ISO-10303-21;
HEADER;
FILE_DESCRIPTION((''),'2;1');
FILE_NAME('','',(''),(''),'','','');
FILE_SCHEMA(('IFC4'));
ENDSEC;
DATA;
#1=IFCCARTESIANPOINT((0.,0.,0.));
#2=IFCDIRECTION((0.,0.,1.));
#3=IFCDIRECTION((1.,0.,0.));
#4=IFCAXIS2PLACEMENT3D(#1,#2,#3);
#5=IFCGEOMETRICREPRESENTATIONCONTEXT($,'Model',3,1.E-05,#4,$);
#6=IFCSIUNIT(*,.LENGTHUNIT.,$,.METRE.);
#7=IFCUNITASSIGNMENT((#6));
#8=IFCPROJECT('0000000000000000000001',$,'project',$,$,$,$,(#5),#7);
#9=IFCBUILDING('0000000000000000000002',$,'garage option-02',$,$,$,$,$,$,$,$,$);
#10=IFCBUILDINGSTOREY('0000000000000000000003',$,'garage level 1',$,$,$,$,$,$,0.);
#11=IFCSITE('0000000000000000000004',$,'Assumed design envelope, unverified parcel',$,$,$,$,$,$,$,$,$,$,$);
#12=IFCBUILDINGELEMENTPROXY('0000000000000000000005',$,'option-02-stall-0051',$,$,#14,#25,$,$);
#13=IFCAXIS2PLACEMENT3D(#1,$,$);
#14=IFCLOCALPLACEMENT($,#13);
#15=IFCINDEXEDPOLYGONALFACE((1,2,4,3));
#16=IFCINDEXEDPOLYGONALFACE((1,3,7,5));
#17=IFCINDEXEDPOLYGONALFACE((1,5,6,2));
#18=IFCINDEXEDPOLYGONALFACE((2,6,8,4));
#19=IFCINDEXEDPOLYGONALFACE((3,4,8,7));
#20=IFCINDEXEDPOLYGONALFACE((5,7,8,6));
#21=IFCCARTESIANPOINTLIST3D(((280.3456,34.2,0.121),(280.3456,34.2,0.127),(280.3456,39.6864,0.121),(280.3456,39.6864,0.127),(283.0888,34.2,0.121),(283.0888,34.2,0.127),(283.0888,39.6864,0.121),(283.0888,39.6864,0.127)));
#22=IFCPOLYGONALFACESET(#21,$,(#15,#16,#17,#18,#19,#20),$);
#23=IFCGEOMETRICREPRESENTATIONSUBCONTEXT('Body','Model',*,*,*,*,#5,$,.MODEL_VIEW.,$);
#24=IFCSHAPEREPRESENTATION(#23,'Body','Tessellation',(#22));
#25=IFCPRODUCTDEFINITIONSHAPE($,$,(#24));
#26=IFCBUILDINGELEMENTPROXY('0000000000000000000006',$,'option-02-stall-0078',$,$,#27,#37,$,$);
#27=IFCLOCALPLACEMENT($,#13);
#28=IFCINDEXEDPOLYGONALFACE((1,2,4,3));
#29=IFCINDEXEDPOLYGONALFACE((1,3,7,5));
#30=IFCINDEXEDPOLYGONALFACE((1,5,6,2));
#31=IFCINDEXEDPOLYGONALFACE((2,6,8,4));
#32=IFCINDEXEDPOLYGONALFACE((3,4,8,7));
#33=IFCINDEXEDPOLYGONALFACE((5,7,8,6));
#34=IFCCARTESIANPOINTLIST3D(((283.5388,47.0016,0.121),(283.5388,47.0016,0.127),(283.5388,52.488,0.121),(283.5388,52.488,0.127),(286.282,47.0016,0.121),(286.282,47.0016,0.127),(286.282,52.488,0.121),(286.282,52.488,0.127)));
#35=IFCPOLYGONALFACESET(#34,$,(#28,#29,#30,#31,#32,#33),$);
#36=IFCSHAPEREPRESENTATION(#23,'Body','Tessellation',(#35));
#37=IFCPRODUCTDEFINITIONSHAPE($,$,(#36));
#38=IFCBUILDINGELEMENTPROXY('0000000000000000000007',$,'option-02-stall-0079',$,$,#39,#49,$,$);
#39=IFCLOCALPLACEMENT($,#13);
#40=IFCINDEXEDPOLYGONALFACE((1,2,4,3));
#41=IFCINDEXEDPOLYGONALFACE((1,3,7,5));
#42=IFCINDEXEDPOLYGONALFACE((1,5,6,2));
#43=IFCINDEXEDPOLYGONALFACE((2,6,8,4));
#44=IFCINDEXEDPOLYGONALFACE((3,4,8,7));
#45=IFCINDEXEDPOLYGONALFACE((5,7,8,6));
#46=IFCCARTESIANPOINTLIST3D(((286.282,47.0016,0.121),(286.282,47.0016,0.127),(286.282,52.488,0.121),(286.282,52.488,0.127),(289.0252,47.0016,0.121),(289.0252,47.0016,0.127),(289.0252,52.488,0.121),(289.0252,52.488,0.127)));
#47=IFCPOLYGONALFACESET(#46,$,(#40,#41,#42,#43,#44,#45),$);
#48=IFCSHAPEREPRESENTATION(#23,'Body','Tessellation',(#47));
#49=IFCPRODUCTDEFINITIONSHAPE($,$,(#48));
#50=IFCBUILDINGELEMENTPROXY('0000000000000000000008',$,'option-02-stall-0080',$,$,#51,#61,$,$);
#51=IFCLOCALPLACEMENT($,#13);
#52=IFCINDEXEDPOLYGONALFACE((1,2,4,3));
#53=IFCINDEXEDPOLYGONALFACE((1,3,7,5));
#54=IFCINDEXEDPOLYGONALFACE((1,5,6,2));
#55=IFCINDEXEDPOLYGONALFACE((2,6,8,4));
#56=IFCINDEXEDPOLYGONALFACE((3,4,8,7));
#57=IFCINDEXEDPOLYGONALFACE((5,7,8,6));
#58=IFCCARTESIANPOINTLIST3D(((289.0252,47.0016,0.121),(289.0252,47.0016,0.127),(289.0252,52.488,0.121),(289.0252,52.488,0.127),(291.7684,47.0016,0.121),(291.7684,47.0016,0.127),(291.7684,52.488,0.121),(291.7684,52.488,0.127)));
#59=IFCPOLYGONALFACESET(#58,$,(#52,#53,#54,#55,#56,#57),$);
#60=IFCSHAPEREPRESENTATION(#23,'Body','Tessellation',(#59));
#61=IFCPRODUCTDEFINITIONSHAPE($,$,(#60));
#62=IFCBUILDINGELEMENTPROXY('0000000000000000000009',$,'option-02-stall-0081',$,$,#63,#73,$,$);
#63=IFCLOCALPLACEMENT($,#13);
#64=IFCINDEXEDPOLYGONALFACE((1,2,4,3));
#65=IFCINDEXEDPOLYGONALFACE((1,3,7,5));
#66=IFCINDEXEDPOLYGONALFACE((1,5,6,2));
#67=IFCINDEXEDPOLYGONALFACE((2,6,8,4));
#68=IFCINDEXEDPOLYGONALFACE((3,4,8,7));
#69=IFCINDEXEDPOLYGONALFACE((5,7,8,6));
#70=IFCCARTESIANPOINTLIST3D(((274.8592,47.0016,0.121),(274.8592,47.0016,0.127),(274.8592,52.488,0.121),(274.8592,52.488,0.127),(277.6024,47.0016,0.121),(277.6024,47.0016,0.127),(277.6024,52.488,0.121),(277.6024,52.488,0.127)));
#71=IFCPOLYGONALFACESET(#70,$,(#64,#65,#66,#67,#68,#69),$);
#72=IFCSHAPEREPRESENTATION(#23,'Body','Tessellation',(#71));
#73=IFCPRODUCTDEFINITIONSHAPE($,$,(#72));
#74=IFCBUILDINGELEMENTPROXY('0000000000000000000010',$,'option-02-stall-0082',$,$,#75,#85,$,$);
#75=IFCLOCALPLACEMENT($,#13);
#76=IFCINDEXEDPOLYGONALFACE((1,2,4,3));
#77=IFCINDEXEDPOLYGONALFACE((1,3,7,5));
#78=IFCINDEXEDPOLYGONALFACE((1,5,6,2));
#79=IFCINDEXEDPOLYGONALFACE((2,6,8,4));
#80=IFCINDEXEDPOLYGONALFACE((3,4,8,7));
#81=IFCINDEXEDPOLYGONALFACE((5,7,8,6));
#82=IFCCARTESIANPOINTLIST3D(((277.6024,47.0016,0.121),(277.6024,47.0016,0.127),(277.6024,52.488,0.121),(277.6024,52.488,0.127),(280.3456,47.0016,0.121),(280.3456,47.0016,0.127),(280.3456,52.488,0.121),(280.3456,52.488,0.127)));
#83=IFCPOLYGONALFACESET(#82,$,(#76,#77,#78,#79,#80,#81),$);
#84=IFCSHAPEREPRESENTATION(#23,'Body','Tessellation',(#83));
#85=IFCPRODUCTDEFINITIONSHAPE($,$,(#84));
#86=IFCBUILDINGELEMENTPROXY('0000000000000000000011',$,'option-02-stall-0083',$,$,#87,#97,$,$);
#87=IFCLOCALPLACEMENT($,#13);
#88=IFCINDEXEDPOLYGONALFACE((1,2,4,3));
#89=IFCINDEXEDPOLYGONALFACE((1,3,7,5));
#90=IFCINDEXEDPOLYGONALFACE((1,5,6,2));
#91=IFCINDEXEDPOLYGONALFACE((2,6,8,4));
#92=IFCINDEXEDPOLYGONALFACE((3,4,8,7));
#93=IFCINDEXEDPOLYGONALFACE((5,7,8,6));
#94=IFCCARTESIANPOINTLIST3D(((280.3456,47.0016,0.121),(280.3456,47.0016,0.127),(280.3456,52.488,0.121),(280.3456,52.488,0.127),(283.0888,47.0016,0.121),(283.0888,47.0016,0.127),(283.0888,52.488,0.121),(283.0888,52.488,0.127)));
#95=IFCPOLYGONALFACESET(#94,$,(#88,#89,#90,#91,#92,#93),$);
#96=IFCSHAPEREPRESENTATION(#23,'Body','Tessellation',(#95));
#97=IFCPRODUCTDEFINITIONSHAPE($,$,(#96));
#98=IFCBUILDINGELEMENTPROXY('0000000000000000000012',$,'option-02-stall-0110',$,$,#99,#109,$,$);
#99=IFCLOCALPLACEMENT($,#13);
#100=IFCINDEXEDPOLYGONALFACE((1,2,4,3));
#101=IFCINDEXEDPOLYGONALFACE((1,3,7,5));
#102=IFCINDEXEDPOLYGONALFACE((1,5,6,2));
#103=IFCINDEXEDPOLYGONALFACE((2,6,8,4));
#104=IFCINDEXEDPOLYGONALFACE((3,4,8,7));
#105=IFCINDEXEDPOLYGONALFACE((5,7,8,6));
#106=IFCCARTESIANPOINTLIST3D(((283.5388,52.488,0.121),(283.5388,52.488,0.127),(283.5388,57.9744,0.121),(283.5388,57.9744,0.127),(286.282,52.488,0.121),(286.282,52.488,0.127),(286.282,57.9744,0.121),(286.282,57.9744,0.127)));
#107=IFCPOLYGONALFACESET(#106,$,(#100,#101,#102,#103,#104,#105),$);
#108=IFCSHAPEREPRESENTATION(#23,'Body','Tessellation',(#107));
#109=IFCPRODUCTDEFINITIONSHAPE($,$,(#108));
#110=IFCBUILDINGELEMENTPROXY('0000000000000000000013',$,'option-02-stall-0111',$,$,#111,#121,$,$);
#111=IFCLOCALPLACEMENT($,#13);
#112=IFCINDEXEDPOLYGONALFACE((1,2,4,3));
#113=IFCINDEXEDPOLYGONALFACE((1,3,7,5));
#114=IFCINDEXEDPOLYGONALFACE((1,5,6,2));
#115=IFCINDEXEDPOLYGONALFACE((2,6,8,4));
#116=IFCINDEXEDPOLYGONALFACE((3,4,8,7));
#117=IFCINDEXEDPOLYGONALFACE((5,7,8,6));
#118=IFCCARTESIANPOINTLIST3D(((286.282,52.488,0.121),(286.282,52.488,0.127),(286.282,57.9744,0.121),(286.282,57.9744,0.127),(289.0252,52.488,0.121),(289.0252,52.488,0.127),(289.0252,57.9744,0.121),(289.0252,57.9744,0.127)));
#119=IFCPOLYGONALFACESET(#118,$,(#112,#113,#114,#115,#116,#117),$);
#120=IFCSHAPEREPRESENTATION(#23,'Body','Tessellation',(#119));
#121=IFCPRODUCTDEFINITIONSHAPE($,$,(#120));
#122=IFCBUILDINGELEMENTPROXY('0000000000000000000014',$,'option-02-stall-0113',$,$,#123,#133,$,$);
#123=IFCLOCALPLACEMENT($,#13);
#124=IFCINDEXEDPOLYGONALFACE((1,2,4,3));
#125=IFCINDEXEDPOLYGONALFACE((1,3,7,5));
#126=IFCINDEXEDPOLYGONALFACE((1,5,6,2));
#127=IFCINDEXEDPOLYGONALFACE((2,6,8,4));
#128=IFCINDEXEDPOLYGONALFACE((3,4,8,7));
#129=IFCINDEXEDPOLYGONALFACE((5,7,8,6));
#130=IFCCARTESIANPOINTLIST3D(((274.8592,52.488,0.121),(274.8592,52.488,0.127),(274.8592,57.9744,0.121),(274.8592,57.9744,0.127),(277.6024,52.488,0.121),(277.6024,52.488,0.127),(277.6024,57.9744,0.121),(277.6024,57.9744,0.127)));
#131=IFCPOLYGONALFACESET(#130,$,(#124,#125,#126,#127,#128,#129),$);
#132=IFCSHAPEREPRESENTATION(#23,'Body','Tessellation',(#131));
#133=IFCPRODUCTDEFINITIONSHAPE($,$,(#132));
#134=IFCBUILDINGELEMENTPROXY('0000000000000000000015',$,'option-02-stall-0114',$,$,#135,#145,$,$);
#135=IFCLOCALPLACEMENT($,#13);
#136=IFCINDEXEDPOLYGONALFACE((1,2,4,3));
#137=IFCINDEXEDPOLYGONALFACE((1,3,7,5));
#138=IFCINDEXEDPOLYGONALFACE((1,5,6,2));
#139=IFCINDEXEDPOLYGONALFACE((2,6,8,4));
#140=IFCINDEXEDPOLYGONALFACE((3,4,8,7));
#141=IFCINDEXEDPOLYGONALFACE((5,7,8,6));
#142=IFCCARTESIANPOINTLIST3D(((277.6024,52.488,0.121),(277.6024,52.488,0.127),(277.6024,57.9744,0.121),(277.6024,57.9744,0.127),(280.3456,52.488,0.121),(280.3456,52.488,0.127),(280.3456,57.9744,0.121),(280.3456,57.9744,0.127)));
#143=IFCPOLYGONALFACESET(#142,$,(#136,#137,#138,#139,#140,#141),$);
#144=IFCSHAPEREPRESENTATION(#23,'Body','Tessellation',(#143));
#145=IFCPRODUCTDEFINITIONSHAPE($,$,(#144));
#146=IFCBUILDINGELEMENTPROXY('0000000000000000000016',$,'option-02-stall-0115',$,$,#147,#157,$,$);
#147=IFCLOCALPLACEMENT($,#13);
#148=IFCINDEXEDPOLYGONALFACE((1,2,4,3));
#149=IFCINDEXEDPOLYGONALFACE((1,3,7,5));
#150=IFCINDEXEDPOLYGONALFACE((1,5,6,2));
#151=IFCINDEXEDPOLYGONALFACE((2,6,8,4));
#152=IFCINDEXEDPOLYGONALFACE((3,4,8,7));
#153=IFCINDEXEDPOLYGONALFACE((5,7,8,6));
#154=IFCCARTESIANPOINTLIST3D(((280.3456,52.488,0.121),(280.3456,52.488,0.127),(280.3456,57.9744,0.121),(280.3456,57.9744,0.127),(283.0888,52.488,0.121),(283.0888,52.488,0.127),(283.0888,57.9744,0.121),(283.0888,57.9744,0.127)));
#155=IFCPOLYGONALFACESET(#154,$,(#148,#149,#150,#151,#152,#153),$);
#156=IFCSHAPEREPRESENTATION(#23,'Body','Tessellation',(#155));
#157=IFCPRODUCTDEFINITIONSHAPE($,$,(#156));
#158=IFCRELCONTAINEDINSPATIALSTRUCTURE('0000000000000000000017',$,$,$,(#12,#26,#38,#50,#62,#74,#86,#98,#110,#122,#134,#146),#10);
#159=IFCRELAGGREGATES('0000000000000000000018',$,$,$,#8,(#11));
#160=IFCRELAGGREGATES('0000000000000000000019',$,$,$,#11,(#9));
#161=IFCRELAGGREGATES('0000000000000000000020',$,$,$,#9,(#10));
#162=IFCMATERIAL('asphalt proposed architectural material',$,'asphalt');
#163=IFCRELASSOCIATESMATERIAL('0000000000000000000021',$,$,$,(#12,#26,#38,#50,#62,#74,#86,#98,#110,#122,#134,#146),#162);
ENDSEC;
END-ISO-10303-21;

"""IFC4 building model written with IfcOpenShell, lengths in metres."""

from ifc_helpers import new_model, si_unit, frame, origin_with_axes, place, context, subcontext, project, spatial, rectangle, extrude, material, element, save


model = new_model("IFC4")

# Units and contexts
model_context = context("Model", 3, precision=1e-05, world=origin_with_axes())
body_context = subcontext(model_context, "Body", "Model", "MODEL_VIEW")
ifc_project = project(units=[si_unit("LENGTHUNIT", "METRE")], contexts=[model_context])

# Site, building, storey
site = spatial("IfcSite", under=ifc_project, Name="Assumed design envelope, unverified parcel")
building = spatial("IfcBuilding", under=site, Name="garage option-02")
storey = spatial("IfcBuildingStorey", under=building, Name="garage level 1", Elevation=0.0)

# Building element proxies
ifc_material_1 = material(Name="asphalt proposed architectural material", Category="asphalt")
for number, where, z_axis, x_axis, name in (
    (1, (281.7172, 36.9432, 0.121), (0.0, 0.0, 1.0), (1.0, 0.0, 0.0), "option-02-stall-0051"),
    (2, (284.9104, 49.7448, 0.121), (0.0, 0.0, 1.0), (1.0, 0.0, 0.0), "option-02-stall-0078"),
    (3, (287.6536, 49.7448, 0.121), (0.0, 0.0, 1.0), (1.0, 0.0, 0.0), "option-02-stall-0079"),
    (4, (290.3968, 49.7448, 0.121), (0.0, 0.0, 1.0), (1.0, 0.0, 0.0), "option-02-stall-0080"),
    (5, (276.2308, 49.7448, 0.121), (0.0, 0.0, 1.0), (1.0, 0.0, 0.0), "option-02-stall-0081"),
    (6, (278.974, 49.7448, 0.121), (0.0, 0.0, 1.0), (1.0, 0.0, 0.0), "option-02-stall-0082"),
    (7, (281.7172, 49.7448, 0.121), (0.0, 0.0, 1.0), (1.0, 0.0, 0.0), "option-02-stall-0083"),
):
    element("IfcBuildingElementProxy", number, at=place(None, frame(where, z_axis=z_axis, x_axis=x_axis)), inside=storey, material=ifc_material_1, Name=name, context=body_context, shape_type="SweptSolid", body=[
        extrude(rectangle(XDim=2.7432, YDim=5.4864), origin_with_axes(), (0.0, 0.0, 1.0), 0.006),
    ])
for number, where, z_axis, x_axis, name in (
    (8, (284.9104, 55.2312, 0.121), (0.0, 0.0, 1.0), (1.0, 0.0, 0.0), "option-02-stall-0110"),
    (9, (287.6536, 55.2312, 0.121), (0.0, 0.0, 1.0), (1.0, 0.0, 0.0), "option-02-stall-0111"),
    (10, (276.2308, 55.2312, 0.121), (0.0, 0.0, 1.0), (1.0, 0.0, 0.0), "option-02-stall-0113"),
    (11, (278.974, 55.2312, 0.121), (0.0, 0.0, 1.0), (1.0, 0.0, 0.0), "option-02-stall-0114"),
    (12, (281.7172, 55.2312, 0.121), (0.0, 0.0, 1.0), (1.0, 0.0, 0.0), "option-02-stall-0115"),
):
    element("IfcBuildingElementProxy", number, at=place(None, frame(where, z_axis=z_axis, x_axis=x_axis)), inside=storey, material=ifc_material_1, Name=name, context=body_context, shape_type="SweptSolid", body=[
        extrude(rectangle(XDim=2.7432, YDim=5.4864), origin_with_axes(), (0.0, 0.0, 1.0), 0.006),
    ])

save(model, "model.ifc")
